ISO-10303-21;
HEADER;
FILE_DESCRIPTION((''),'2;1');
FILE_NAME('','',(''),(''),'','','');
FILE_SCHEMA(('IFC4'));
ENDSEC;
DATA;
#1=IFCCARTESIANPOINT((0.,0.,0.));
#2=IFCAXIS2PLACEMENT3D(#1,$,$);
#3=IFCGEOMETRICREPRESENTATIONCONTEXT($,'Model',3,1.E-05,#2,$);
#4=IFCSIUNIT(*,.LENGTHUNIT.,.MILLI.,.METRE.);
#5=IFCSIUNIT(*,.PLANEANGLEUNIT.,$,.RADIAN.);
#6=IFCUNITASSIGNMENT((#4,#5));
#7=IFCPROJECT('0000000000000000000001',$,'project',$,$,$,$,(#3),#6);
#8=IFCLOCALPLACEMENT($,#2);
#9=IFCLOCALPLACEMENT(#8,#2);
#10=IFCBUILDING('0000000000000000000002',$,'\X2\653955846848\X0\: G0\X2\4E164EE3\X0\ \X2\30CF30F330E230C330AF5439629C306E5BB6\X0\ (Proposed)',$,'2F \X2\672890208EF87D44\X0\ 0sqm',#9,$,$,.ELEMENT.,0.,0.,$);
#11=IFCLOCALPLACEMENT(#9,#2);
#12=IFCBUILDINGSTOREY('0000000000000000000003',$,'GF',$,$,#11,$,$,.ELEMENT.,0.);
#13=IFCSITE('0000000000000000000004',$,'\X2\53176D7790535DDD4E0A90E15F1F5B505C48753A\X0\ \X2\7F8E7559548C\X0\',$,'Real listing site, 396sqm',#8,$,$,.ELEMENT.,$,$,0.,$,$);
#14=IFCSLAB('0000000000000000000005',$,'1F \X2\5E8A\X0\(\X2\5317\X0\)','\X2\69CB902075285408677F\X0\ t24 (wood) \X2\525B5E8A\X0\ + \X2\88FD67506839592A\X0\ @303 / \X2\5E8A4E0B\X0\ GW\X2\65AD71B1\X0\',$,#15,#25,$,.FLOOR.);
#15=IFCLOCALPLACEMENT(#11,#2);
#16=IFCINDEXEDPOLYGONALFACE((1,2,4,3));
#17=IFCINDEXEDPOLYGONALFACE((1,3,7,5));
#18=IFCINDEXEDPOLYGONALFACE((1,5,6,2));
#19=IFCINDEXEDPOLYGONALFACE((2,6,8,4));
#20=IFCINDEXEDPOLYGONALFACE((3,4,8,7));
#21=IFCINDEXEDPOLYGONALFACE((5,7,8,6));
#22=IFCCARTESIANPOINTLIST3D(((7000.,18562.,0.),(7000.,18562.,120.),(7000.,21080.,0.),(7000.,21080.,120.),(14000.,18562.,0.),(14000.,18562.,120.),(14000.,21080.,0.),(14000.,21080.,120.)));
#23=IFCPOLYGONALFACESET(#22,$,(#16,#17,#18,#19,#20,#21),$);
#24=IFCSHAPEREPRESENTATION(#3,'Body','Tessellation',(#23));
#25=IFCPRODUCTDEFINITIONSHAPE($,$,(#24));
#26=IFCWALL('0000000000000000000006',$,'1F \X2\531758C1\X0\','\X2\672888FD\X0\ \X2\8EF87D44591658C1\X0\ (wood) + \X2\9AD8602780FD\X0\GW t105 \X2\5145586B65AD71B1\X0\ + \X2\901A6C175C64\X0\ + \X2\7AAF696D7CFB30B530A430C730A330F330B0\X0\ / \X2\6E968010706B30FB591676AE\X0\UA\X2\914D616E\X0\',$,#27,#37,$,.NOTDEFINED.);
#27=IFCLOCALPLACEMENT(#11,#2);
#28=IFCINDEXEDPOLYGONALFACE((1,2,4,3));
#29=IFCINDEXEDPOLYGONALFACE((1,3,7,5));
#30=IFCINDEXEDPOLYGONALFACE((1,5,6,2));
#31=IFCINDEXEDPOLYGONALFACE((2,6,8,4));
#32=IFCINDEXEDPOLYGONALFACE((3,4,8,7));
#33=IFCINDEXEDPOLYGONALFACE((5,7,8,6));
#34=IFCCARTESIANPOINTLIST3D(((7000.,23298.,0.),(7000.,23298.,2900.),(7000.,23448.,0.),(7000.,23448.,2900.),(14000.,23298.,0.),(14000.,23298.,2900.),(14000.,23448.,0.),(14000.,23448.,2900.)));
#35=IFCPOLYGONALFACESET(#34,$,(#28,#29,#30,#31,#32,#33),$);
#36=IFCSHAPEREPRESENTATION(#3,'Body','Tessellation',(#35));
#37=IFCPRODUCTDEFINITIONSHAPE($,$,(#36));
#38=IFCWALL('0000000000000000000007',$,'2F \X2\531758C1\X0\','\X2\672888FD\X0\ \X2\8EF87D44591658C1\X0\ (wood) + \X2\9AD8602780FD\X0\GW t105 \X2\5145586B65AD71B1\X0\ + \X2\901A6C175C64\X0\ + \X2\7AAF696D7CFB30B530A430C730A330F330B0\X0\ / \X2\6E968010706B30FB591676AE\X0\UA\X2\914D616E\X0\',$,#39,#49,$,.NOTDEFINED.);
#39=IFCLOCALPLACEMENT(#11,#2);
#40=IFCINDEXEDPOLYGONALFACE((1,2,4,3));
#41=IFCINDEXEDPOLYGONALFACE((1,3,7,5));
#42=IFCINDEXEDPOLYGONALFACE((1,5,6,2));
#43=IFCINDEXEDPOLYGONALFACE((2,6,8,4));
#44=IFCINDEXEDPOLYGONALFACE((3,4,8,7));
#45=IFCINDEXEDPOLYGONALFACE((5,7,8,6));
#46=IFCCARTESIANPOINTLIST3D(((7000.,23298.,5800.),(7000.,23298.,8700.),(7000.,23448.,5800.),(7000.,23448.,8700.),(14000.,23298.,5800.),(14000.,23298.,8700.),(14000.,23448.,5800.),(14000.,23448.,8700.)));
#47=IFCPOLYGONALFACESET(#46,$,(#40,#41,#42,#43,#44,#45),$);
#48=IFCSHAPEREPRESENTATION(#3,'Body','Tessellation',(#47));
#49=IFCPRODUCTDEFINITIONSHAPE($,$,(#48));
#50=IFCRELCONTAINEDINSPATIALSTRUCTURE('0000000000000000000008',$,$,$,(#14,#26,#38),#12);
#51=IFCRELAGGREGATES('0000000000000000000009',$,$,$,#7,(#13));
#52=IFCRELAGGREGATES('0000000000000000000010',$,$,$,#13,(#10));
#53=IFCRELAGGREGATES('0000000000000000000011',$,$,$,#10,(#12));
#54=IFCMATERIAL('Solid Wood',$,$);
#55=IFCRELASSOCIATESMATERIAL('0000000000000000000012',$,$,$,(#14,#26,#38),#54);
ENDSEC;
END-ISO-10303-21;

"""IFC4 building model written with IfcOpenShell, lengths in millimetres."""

from ifc_helpers import new_model, si_unit, frame, frame_2d, origin, place, context, project, spatial, rectangle, extrude, material, element, save


model = new_model("IFC4")

# Units and contexts
model_context = context("Model", 3, precision=1e-05, world=origin())
ifc_project = project(units=[si_unit("LENGTHUNIT", "METRE", prefix="MILLI"), si_unit("PLANEANGLEUNIT", "RADIAN")], contexts=[model_context])

# Site, building, storey
site_placement = place(None, origin())
site = spatial("IfcSite", under=ifc_project, at=site_placement, Name="北海道川上郡弟子屈町 美留和", ObjectType="Real listing site, 396sqm", CompositionType="ELEMENT", RefElevation=0.0)
building_placement = place(site_placement, origin())
building = spatial("IfcBuilding", under=site, at=building_placement, Name="改善案: G0世代 ハンモック吹抜の家 (Proposed)", ObjectType="2F 木造軸組 0sqm", CompositionType="ELEMENT", ElevationOfRefHeight=0.0, ElevationOfTerrain=0.0)
storey_placement = place(building_placement, origin())
storey = spatial("IfcBuildingStorey", under=building, at=storey_placement, Name="GF", CompositionType="ELEMENT", Elevation=0.0)

# Slab
ifc_material_1 = material(Name="Solid Wood")
slab_1_placement = place(storey_placement, frame((3500.0, 9281.0, 0.0)))
element("IfcSlab", 1, at=slab_1_placement, inside=storey, material=ifc_material_1, Name="1F 床(北)", Description="構造用合板 t24 (wood) 剛床 + 製材根太 @303 / 床下 GW断熱", PredefinedType="FLOOR", context=model_context, shape_type="SweptSolid", body=[
    extrude(rectangle(XDim=7000.0, YDim=2518.0, at=frame_2d((3500.0, 1259.0))), frame((3500.0, 9281.0, 0.0)), (0.0, 0.0, 1.0), 120.0),
])

# Wall
wall_1_placement = place(storey_placement, frame((3500.0, 11649.0, 0.0)))
element("IfcWall", 2, at=wall_1_placement, inside=storey, material=ifc_material_1, Name="1F 北壁", Description="木製 軸組外壁 (wood) + 高性能GW t105 充填断熱 + 通気層 + 窯業系サイディング / 準耐火・外皮UA配慮", PredefinedType="NOTDEFINED", context=model_context, shape_type="SweptSolid", body=[
    extrude(rectangle(XDim=7000.0, YDim=150.0, at=frame_2d((3500.0, 75.0))), frame((3500.0, 11649.0, 0.0)), (0.0, 0.0, 1.0), 2900.0),
])

# Wall
wall_2_placement = place(storey_placement, frame((3500.0, 11649.0, 2900.0)))
element("IfcWall", 3, at=wall_2_placement, inside=storey, material=ifc_material_1, Name="2F 北壁", Description="木製 軸組外壁 (wood) + 高性能GW t105 充填断熱 + 通気層 + 窯業系サイディング / 準耐火・外皮UA配慮", PredefinedType="NOTDEFINED", context=model_context, shape_type="SweptSolid", body=[
    extrude(rectangle(XDim=7000.0, YDim=150.0, at=frame_2d((3500.0, 75.0))), frame((3500.0, 11649.0, 2900.0)), (0.0, 0.0, 1.0), 2900.0),
])

save(model, "model.ifc")
